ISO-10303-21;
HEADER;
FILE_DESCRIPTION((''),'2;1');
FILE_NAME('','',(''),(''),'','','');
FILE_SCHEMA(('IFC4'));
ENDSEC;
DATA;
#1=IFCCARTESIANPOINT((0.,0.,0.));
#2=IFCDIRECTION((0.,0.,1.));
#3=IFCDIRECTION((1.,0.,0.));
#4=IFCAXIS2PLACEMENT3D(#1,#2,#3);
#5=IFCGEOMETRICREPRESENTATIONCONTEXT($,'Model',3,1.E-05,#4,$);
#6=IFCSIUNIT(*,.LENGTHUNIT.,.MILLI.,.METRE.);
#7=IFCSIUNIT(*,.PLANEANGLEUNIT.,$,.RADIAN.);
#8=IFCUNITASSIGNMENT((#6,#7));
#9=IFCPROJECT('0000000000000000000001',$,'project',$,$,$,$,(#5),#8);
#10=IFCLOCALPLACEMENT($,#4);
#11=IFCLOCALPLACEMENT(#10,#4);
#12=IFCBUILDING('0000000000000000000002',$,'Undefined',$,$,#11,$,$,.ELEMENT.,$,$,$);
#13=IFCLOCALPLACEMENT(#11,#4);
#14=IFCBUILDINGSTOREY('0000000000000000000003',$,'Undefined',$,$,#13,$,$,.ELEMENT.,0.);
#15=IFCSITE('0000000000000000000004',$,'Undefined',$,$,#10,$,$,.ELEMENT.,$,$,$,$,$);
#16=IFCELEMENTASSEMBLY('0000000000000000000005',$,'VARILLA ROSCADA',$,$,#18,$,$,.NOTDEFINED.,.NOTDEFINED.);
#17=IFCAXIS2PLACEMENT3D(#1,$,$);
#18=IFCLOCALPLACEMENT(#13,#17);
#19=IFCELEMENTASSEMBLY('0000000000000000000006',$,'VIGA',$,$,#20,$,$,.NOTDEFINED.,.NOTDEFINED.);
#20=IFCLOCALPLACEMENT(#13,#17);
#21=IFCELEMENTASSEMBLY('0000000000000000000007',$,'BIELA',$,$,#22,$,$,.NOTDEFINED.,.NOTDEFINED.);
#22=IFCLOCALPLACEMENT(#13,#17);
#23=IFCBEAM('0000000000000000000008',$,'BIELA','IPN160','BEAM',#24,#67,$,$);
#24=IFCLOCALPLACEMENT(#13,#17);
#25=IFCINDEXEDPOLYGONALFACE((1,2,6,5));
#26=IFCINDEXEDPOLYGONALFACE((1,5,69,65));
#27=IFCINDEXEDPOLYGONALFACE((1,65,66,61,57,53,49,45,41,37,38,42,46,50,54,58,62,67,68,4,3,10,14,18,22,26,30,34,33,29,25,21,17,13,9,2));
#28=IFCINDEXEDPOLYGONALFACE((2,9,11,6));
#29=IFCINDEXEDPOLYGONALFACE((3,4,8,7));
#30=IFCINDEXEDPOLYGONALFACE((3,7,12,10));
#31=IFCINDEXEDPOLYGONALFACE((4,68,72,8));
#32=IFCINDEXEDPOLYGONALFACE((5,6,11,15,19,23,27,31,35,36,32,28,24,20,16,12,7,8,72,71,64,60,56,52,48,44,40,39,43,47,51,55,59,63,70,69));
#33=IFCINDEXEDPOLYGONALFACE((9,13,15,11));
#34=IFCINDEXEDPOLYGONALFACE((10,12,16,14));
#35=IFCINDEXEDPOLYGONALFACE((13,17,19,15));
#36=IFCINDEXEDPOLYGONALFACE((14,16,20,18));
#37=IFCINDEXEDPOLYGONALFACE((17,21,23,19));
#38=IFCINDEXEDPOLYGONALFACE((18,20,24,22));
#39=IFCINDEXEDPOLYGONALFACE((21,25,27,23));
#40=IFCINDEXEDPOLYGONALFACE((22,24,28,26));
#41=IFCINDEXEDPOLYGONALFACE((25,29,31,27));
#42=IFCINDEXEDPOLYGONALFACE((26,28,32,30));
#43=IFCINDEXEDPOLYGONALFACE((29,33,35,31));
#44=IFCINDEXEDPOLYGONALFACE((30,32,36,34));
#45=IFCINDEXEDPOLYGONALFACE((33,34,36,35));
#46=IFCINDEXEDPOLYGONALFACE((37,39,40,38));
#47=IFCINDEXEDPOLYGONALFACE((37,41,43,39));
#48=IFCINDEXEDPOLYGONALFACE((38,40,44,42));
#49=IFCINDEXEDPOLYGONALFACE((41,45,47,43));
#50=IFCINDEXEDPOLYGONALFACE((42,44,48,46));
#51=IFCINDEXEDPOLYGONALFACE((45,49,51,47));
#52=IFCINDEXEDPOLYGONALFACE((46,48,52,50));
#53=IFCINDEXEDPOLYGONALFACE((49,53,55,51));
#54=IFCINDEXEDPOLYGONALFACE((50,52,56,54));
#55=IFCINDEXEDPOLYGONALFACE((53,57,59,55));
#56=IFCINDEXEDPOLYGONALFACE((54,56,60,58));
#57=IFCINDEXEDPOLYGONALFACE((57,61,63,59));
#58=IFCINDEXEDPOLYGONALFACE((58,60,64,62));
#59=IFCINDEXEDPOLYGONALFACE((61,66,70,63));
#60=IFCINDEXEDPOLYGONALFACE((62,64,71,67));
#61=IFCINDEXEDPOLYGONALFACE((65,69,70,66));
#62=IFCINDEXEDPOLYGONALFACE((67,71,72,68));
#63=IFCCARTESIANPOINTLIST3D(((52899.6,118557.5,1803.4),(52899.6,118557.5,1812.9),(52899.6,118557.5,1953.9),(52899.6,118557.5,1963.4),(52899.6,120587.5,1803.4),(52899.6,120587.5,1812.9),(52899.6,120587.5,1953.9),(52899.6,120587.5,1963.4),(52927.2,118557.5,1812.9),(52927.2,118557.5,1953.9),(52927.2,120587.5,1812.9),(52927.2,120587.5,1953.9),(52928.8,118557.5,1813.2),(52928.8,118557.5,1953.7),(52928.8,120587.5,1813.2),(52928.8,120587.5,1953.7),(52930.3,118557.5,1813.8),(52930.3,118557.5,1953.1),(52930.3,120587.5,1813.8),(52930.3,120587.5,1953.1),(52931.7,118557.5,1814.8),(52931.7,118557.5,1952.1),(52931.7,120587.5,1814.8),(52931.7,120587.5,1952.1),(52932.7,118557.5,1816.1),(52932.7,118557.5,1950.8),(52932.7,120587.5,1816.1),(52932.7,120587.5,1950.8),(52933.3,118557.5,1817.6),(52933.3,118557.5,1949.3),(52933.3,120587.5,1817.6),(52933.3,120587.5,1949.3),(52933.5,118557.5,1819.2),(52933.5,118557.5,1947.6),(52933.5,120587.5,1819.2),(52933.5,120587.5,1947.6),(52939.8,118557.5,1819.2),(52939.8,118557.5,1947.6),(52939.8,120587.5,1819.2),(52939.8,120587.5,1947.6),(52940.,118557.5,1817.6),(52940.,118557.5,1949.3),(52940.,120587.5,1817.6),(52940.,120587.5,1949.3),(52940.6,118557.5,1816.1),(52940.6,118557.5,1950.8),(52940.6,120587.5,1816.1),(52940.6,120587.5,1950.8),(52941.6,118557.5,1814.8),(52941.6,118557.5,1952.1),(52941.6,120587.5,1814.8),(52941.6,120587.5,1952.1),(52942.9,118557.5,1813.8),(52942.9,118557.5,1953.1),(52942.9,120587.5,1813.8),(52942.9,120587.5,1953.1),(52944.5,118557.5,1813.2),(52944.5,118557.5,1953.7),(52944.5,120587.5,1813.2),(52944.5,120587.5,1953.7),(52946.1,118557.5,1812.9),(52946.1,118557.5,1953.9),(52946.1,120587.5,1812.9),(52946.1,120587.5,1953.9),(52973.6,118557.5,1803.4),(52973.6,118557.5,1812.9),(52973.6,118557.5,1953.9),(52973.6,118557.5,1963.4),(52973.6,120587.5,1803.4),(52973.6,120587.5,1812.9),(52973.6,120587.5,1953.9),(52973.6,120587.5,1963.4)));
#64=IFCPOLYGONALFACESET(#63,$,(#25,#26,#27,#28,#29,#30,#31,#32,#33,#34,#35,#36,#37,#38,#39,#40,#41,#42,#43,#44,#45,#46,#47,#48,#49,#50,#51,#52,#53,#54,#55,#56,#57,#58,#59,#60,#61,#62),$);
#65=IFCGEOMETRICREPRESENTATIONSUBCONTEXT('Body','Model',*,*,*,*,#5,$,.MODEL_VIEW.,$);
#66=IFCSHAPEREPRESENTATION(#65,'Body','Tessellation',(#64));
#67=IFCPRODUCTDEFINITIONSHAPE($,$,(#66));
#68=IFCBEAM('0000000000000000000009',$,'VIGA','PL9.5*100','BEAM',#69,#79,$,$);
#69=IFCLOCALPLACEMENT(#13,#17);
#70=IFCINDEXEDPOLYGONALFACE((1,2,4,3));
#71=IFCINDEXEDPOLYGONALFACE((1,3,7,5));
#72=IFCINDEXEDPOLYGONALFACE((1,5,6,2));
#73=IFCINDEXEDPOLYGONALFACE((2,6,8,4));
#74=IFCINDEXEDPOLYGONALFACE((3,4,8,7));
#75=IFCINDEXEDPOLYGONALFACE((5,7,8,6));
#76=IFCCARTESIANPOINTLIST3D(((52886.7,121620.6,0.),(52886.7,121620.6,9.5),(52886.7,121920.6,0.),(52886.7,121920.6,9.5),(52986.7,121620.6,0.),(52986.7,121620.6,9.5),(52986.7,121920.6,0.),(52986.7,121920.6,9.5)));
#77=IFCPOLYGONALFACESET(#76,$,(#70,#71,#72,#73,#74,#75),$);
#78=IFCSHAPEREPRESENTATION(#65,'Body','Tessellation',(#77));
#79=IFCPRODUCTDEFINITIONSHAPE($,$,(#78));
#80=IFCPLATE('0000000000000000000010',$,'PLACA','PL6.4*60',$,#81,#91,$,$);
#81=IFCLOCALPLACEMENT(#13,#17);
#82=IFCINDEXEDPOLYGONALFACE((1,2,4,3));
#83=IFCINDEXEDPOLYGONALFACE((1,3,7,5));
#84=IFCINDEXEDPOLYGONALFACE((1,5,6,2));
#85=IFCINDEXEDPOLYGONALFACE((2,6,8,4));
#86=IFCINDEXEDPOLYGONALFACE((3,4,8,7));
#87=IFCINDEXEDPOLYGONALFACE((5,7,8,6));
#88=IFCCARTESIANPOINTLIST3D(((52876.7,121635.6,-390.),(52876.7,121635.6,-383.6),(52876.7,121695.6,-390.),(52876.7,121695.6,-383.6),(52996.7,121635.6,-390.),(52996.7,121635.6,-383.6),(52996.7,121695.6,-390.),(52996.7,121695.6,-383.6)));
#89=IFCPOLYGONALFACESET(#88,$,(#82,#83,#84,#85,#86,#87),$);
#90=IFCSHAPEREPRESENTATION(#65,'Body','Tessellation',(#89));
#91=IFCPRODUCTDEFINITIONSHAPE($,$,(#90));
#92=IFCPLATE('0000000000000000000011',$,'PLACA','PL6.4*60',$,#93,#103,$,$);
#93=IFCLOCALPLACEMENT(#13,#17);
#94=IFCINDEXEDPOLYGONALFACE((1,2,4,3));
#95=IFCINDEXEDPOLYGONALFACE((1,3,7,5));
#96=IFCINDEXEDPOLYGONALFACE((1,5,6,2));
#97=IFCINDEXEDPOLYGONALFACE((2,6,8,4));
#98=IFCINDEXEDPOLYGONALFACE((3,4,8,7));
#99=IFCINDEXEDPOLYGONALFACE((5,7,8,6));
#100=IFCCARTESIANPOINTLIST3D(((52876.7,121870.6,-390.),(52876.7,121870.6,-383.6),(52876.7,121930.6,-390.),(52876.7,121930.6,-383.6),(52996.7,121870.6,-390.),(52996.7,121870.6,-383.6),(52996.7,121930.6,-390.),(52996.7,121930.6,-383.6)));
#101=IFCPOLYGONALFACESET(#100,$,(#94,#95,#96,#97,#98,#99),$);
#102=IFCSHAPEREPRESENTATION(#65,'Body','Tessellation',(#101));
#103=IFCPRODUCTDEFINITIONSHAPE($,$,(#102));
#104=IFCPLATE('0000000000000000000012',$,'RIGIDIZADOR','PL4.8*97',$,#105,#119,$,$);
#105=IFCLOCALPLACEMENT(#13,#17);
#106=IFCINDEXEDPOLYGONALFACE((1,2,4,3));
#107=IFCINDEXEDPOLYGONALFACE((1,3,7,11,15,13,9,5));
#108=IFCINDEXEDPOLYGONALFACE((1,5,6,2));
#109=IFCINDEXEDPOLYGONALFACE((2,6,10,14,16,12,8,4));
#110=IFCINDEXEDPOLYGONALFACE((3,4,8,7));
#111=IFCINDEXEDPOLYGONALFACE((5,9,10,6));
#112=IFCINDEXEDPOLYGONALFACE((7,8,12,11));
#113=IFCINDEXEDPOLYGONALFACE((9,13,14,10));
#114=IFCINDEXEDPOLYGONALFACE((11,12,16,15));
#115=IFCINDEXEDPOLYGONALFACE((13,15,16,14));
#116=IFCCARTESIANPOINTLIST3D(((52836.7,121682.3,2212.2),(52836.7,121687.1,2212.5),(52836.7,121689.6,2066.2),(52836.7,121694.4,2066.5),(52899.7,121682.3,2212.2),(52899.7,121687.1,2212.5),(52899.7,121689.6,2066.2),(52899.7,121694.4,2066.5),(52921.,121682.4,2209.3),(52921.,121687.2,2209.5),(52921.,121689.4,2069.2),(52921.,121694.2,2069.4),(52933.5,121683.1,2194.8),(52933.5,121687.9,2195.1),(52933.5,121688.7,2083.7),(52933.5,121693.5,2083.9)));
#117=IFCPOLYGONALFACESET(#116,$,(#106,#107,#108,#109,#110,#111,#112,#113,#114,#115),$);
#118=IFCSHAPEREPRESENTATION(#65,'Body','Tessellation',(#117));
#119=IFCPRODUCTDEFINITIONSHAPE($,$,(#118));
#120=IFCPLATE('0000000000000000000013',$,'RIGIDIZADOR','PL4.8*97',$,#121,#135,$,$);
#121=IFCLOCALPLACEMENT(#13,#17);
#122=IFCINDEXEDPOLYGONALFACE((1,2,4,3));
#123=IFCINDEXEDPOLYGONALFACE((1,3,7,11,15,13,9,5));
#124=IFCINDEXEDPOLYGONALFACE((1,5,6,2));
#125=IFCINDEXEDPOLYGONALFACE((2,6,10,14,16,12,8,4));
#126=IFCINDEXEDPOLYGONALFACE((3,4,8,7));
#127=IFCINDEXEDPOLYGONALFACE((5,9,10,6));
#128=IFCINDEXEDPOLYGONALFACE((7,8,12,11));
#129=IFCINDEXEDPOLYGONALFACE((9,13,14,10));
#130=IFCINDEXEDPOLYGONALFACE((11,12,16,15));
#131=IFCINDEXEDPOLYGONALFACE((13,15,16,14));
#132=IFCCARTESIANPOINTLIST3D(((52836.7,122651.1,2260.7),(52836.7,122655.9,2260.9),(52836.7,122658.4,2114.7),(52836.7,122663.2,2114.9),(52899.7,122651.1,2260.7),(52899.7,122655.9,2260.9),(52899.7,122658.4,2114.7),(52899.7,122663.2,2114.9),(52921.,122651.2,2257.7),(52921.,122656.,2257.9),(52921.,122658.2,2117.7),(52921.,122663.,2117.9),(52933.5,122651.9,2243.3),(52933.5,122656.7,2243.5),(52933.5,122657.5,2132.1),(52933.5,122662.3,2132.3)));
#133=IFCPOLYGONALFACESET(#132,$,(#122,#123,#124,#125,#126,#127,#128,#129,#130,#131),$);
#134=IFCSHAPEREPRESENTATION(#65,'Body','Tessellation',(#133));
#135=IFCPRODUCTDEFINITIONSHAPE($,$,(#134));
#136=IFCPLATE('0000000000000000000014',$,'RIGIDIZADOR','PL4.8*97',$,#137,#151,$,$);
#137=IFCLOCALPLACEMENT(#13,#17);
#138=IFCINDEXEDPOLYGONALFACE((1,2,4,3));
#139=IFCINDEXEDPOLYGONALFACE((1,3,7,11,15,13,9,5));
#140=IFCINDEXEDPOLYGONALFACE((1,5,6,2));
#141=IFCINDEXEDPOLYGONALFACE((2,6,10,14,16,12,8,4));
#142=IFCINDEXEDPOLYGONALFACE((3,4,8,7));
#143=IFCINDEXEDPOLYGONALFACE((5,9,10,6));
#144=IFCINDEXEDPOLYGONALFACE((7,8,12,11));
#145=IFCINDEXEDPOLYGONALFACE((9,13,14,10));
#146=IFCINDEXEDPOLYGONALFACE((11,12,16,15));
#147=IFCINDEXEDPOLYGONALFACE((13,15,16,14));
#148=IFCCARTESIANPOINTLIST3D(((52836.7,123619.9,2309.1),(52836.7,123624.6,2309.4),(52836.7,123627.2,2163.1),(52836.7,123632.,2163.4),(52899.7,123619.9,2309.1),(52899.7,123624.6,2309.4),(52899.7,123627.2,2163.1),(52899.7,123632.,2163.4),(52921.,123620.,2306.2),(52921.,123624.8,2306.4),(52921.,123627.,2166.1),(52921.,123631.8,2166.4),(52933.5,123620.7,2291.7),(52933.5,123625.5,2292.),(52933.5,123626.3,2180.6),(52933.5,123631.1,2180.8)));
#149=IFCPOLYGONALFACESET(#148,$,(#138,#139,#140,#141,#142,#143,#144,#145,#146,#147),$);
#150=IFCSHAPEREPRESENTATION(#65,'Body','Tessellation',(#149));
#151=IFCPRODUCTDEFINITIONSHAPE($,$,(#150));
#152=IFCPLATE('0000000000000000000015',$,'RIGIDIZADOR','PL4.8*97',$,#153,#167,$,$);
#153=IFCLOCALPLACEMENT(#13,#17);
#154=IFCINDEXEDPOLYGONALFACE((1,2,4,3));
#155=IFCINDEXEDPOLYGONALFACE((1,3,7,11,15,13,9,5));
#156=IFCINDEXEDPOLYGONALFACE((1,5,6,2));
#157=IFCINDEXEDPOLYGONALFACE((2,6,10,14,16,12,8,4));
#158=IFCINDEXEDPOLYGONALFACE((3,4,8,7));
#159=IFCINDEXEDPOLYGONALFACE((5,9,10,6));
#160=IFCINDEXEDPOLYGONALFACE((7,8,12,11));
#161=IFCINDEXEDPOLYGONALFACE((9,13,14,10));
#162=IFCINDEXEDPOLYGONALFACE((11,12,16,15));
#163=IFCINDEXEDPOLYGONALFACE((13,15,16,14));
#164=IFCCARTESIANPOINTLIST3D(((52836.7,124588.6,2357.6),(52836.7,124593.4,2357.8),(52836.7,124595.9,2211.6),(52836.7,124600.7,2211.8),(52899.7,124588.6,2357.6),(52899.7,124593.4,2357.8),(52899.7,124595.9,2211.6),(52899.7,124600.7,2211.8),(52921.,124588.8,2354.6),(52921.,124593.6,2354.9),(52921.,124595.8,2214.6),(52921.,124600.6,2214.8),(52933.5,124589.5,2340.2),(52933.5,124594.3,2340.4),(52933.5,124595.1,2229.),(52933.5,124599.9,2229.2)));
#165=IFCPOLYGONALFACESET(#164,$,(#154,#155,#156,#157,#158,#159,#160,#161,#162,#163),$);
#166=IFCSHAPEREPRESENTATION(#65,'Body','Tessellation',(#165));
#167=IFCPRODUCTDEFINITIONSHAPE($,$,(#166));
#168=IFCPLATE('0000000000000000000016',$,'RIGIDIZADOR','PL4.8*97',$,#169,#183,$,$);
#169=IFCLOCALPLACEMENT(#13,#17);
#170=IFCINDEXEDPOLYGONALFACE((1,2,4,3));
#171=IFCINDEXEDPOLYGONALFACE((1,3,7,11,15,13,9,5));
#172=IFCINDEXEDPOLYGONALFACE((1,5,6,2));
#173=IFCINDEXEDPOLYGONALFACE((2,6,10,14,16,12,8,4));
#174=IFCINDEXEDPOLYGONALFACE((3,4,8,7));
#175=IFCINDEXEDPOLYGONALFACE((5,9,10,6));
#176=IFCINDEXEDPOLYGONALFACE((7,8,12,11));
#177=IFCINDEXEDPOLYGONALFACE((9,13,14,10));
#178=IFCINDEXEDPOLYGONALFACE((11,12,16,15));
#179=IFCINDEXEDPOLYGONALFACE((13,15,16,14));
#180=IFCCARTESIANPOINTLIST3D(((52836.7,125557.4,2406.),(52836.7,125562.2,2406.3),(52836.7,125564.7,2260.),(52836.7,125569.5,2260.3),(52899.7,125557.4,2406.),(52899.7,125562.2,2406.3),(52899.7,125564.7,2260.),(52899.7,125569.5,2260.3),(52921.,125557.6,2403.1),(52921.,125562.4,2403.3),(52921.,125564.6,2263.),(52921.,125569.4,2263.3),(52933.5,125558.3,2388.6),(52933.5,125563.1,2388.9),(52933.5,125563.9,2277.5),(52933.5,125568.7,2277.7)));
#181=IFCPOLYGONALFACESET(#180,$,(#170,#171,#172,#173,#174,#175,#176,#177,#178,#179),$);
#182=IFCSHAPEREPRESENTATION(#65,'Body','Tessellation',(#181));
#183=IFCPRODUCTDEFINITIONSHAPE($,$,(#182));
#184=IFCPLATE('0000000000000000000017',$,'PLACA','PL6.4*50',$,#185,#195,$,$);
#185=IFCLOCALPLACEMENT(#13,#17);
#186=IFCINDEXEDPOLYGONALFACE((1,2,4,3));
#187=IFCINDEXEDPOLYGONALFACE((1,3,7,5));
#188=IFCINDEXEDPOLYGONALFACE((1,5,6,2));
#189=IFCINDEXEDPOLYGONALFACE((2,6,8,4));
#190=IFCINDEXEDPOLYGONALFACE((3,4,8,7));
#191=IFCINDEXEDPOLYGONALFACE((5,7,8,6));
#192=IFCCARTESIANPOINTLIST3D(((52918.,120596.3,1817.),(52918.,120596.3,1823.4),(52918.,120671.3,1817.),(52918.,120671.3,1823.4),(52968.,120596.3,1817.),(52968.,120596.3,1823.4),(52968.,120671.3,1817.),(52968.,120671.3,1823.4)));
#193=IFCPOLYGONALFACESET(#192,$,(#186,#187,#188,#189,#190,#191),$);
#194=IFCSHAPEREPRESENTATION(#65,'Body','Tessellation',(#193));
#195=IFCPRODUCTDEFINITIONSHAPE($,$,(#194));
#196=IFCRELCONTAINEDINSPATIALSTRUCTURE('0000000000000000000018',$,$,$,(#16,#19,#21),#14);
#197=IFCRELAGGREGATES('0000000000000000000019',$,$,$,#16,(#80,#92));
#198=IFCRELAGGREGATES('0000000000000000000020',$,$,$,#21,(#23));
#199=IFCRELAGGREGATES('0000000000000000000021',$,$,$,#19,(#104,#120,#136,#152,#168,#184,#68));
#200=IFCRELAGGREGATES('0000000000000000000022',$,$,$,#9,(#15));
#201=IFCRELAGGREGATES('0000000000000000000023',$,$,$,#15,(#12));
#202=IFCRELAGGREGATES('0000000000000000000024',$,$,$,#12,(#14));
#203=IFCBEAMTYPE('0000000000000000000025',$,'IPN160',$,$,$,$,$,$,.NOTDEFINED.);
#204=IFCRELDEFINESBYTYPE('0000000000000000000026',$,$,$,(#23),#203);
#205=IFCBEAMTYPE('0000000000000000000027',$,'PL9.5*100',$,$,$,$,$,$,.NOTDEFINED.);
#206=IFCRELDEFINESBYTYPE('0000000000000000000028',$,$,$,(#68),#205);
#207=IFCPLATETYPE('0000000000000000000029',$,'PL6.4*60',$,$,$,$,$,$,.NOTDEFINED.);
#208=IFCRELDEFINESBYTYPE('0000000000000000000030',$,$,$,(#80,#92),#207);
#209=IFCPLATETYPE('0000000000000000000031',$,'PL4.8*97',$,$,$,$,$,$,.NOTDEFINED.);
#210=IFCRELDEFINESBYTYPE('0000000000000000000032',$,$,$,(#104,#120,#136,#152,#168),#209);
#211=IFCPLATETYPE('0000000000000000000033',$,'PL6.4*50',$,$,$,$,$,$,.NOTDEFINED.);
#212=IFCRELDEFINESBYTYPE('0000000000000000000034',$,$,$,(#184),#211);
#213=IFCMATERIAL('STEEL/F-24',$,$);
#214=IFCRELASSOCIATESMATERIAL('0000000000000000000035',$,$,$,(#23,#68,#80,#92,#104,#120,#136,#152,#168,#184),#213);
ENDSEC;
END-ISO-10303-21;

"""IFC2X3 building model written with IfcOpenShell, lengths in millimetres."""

from ifc_helpers import new_model, si_unit, frame, origin_with_axes, origin_2d_with_axis, place, context, subcontext, project, spatial, polyline, rectangle, i_section, outline, extrude, material, type_object, element, aggregate, save


model = new_model("IFC2X3")

# Units and contexts
model_context = context("Model", 3, precision=1e-05, world=origin_with_axes())
body_context = subcontext(model_context, "Body", "Model", "MODEL_VIEW")
ifc_project = project(units=[si_unit("LENGTHUNIT", "METRE", prefix="MILLI"), si_unit("PLANEANGLEUNIT", "RADIAN")], contexts=[model_context])

# Site, building, storey
site_placement = place(None, origin_with_axes())
site = spatial("IfcSite", under=ifc_project, at=site_placement, Name="Undefined", CompositionType="ELEMENT")
building_placement = place(site_placement, origin_with_axes())
building = spatial("IfcBuilding", under=site, at=building_placement, Name="Undefined", CompositionType="ELEMENT")
storey_placement = place(building_placement, origin_with_axes())
storey = spatial("IfcBuildingStorey", under=building, at=storey_placement, Name="Undefined", CompositionType="ELEMENT", Elevation=0.0)

# Element assembly
assembly_1_placement = place(storey_placement, origin_with_axes())
assembly_1 = element("IfcElementAssembly", 1, at=assembly_1_placement, inside=storey, Name="VARILLA ROSCADA", AssemblyPlace="NOTDEFINED", PredefinedType="NOTDEFINED")

# Element assembly
assembly_2_placement = place(storey_placement, origin_with_axes())
assembly_2 = element("IfcElementAssembly", 2, at=assembly_2_placement, inside=storey, Name="VIGA", AssemblyPlace="NOTDEFINED", PredefinedType="NOTDEFINED")
ifc_material_1 = material(Name="STEEL/F-24")
beam_type_1 = type_object("IfcBeamType", Name="IPN160", PredefinedType="NOTDEFINED")

# Element assembly, beam
assembly_3_placement = place(storey_placement, origin_with_axes())
assembly_3 = element("IfcElementAssembly", 3, at=assembly_3_placement, inside=storey, Name="BIELA", AssemblyPlace="NOTDEFINED", PredefinedType="NOTDEFINED")
beam_1_placement = place(assembly_3_placement, frame((52936.6, 120587.5, 1883.4), z_axis=(0.0, 0.000002, 1.0), x_axis=(0.0, -1.0, 0.000002)))
beam_1 = element("IfcBeam", 4, at=beam_1_placement, type_object=beam_type_1, material=ifc_material_1, Name="BIELA", Description="IPN160", ObjectType="BEAM", context=body_context, shape_type="SweptSolid", body=[
    extrude(i_section(OverallWidth=74.0, OverallDepth=160.0, WebThickness=6.3, FlangeThickness=9.5, FilletRadius=6.3, at=origin_2d_with_axis()), frame((2030.0, 0.0, 0.0), z_axis=(-1.0, 0.0, 0.0), x_axis=(0.0, -1.0, 0.0)), (0.0, 0.0, 1.0), 2030.0),
])

# Beam
beam_type_2 = type_object("IfcBeamType", Name="PL9.5*100", PredefinedType="NOTDEFINED")
beam_2_placement = place(assembly_2_placement, frame((52936.7, 121620.6, 4.7), z_axis=(1.0, 0.0, 0.0), x_axis=(0.0, 1.0, 0.0)))
beam_2 = element("IfcBeam", 5, at=beam_2_placement, type_object=beam_type_2, material=ifc_material_1, Name="VIGA", Description="PL9.5*100", ObjectType="BEAM", context=body_context, shape_type="SweptSolid", body=[
    extrude(rectangle(XDim=9.5, YDim=100.0, at=origin_2d_with_axis()), frame((300.0, 0.0, 0.0), z_axis=(-1.0, 0.0, 0.0), x_axis=(0.0, -1.0, 0.0)), (0.0, 0.0, 1.0), 300.0),
])

# Plates
plate_type_1 = type_object("IfcPlateType", Name="PL6.4*60", PredefinedType="NOTDEFINED")
plate_1_placement = place(assembly_1_placement, frame((52876.7, 121635.6, -386.8), z_axis=(0.0, 0.0, 1.0), x_axis=(1.0, 0.0, 0.0)))
plate_1 = element("IfcPlate", 6, at=plate_1_placement, type_object=plate_type_1, material=ifc_material_1, Name="PLACA", Description="PL6.4*60", context=body_context, shape_type="SweptSolid", body=[
    extrude(outline(polyline([(0.0, 0.0), (120.0, 0.0), (120.0, 60.0), (0.0, 60.0), (0.0, 0.0)])), frame((0.0, 0.0, -3.2), z_axis=(0.0, 0.0, 1.0), x_axis=(1.0, 0.0, 0.0)), (0.0, 0.0, 1.0), 6.4),
])
plate_2_placement = place(assembly_1_placement, frame((52876.7, 121870.6, -386.8), z_axis=(0.0, 0.0, 1.0), x_axis=(1.0, 0.0, 0.0)))
plate_2 = element("IfcPlate", 7, at=plate_2_placement, type_object=plate_type_1, material=ifc_material_1, Name="PLACA", Description="PL6.4*60", context=body_context, shape_type="SweptSolid", body=[
    extrude(outline(polyline([(0.0, 0.0), (120.0, 0.0), (120.0, 60.0), (0.0, 60.0), (0.0, 0.0)])), frame((0.0, 0.0, -3.2), z_axis=(0.0, 0.0, 1.0), x_axis=(1.0, 0.0, 0.0)), (0.0, 0.0, 1.0), 6.4),
])
plate_type_2 = type_object("IfcPlateType", Name="PL4.8*97", PredefinedType="NOTDEFINED")
plate_3_placement = place(assembly_2_placement, frame((52836.7, 121684.7, 2212.4), z_axis=(0.0, 0.998752, 0.04995), x_axis=(1.0, 0.0, 0.0)))
plate_3 = element("IfcPlate", 8, at=plate_3_placement, type_object=plate_type_2, material=ifc_material_1, Name="RIGIDIZADOR", Description="PL4.8*97", context=body_context, shape_type="SweptSolid", body=[
    extrude(outline(polyline([(0.0, 0.0), (63.0, 0.0), (84.3, 3.0), (96.8, 17.4), (96.8, 128.7), (84.3, 143.2), (63.0, 146.2), (0.0, 146.2), (0.0, 0.0)])), frame((0.0, 0.0, -2.4), z_axis=(0.0, 0.0, 1.0), x_axis=(1.0, 0.0, 0.0)), (0.0, 0.0, 1.0), 4.8),
])
plate_4_placement = place(assembly_2_placement, frame((52836.7, 122653.5, 2260.8), z_axis=(0.0, 0.998752, 0.04995), x_axis=(1.0, 0.0, 0.0)))
plate_4 = element("IfcPlate", 9, at=plate_4_placement, type_object=plate_type_2, material=ifc_material_1, Name="RIGIDIZADOR", Description="PL4.8*97", context=body_context, shape_type="SweptSolid", body=[
    extrude(outline(polyline([(0.0, 0.0), (63.0, 0.0), (84.3, 3.0), (96.8, 17.4), (96.8, 128.7), (84.3, 143.2), (63.0, 146.2), (0.0, 146.2), (0.0, 0.0)])), frame((0.0, 0.0, -2.4), z_axis=(0.0, 0.0, 1.0), x_axis=(1.0, 0.0, 0.0)), (0.0, 0.0, 1.0), 4.8),
])
plate_5_placement = place(assembly_2_placement, frame((52836.7, 123622.3, 2309.3), z_axis=(0.0, 0.998752, 0.04995), x_axis=(1.0, 0.0, 0.0)))
plate_5 = element("IfcPlate", 10, at=plate_5_placement, type_object=plate_type_2, material=ifc_material_1, Name="RIGIDIZADOR", Description="PL4.8*97", context=body_context, shape_type="SweptSolid", body=[
    extrude(outline(polyline([(0.0, 0.0), (63.0, 0.0), (84.3, 3.0), (96.8, 17.4), (96.8, 128.7), (84.3, 143.2), (63.0, 146.2), (0.0, 146.2), (0.0, 0.0)])), frame((0.0, 0.0, -2.4), z_axis=(0.0, 0.0, 1.0), x_axis=(1.0, 0.0, 0.0)), (0.0, 0.0, 1.0), 4.8),
])
plate_6_placement = place(assembly_2_placement, frame((52836.7, 124591.0, 2357.7), z_axis=(0.0, 0.998752, 0.04995), x_axis=(1.0, 0.0, 0.0)))
plate_6 = element("IfcPlate", 11, at=plate_6_placement, type_object=plate_type_2, material=ifc_material_1, Name="RIGIDIZADOR", Description="PL4.8*97", context=body_context, shape_type="SweptSolid", body=[
    extrude(outline(polyline([(0.0, 0.0), (63.0, 0.0), (84.3, 3.0), (96.8, 17.4), (96.8, 128.7), (84.3, 143.2), (63.0, 146.2), (0.0, 146.2), (0.0, 0.0)])), frame((0.0, 0.0, -2.4), z_axis=(0.0, 0.0, 1.0), x_axis=(1.0, 0.0, 0.0)), (0.0, 0.0, 1.0), 4.8),
])
plate_7_placement = place(assembly_2_placement, frame((52836.7, 125559.8, 2406.2), z_axis=(0.0, 0.998752, 0.04995), x_axis=(1.0, 0.0, 0.0)))
plate_7 = element("IfcPlate", 12, at=plate_7_placement, type_object=plate_type_2, material=ifc_material_1, Name="RIGIDIZADOR", Description="PL4.8*97", context=body_context, shape_type="SweptSolid", body=[
    extrude(outline(polyline([(0.0, 0.0), (63.0, 0.0), (84.3, 3.0), (96.8, 17.4), (96.8, 128.7), (84.3, 143.2), (63.0, 146.2), (0.0, 146.2), (0.0, 0.0)])), frame((0.0, 0.0, -2.4), z_axis=(0.0, 0.0, 1.0), x_axis=(1.0, 0.0, 0.0)), (0.0, 0.0, 1.0), 4.8),
])
plate_type_3 = type_object("IfcPlateType", Name="PL6.4*50", PredefinedType="NOTDEFINED")
plate_8_placement = place(assembly_2_placement, frame((52918.0, 120671.3, 1820.2), z_axis=(0.0, 0.0, 1.0), x_axis=(0.0, -1.0, 0.0)))
plate_8 = element("IfcPlate", 13, at=plate_8_placement, type_object=plate_type_3, material=ifc_material_1, Name="PLACA", Description="PL6.4*50", context=body_context, shape_type="SweptSolid", body=[
    extrude(outline(polyline([(0.0, 0.0), (75.0, 0.0), (75.0, 50.0), (0.0, 50.0), (0.0, 0.0)])), frame((0.0, 0.0, -3.2), z_axis=(0.0, 0.0, 1.0), x_axis=(1.0, 0.0, 0.0)), (0.0, 0.0, 1.0), 6.4),
])

aggregate(assembly_1, [plate_1, plate_2])
aggregate(assembly_3, [beam_1])
aggregate(assembly_2, [plate_3, plate_4, plate_5, plate_6, plate_7, plate_8, beam_2])

save(model, "model.ifc")
